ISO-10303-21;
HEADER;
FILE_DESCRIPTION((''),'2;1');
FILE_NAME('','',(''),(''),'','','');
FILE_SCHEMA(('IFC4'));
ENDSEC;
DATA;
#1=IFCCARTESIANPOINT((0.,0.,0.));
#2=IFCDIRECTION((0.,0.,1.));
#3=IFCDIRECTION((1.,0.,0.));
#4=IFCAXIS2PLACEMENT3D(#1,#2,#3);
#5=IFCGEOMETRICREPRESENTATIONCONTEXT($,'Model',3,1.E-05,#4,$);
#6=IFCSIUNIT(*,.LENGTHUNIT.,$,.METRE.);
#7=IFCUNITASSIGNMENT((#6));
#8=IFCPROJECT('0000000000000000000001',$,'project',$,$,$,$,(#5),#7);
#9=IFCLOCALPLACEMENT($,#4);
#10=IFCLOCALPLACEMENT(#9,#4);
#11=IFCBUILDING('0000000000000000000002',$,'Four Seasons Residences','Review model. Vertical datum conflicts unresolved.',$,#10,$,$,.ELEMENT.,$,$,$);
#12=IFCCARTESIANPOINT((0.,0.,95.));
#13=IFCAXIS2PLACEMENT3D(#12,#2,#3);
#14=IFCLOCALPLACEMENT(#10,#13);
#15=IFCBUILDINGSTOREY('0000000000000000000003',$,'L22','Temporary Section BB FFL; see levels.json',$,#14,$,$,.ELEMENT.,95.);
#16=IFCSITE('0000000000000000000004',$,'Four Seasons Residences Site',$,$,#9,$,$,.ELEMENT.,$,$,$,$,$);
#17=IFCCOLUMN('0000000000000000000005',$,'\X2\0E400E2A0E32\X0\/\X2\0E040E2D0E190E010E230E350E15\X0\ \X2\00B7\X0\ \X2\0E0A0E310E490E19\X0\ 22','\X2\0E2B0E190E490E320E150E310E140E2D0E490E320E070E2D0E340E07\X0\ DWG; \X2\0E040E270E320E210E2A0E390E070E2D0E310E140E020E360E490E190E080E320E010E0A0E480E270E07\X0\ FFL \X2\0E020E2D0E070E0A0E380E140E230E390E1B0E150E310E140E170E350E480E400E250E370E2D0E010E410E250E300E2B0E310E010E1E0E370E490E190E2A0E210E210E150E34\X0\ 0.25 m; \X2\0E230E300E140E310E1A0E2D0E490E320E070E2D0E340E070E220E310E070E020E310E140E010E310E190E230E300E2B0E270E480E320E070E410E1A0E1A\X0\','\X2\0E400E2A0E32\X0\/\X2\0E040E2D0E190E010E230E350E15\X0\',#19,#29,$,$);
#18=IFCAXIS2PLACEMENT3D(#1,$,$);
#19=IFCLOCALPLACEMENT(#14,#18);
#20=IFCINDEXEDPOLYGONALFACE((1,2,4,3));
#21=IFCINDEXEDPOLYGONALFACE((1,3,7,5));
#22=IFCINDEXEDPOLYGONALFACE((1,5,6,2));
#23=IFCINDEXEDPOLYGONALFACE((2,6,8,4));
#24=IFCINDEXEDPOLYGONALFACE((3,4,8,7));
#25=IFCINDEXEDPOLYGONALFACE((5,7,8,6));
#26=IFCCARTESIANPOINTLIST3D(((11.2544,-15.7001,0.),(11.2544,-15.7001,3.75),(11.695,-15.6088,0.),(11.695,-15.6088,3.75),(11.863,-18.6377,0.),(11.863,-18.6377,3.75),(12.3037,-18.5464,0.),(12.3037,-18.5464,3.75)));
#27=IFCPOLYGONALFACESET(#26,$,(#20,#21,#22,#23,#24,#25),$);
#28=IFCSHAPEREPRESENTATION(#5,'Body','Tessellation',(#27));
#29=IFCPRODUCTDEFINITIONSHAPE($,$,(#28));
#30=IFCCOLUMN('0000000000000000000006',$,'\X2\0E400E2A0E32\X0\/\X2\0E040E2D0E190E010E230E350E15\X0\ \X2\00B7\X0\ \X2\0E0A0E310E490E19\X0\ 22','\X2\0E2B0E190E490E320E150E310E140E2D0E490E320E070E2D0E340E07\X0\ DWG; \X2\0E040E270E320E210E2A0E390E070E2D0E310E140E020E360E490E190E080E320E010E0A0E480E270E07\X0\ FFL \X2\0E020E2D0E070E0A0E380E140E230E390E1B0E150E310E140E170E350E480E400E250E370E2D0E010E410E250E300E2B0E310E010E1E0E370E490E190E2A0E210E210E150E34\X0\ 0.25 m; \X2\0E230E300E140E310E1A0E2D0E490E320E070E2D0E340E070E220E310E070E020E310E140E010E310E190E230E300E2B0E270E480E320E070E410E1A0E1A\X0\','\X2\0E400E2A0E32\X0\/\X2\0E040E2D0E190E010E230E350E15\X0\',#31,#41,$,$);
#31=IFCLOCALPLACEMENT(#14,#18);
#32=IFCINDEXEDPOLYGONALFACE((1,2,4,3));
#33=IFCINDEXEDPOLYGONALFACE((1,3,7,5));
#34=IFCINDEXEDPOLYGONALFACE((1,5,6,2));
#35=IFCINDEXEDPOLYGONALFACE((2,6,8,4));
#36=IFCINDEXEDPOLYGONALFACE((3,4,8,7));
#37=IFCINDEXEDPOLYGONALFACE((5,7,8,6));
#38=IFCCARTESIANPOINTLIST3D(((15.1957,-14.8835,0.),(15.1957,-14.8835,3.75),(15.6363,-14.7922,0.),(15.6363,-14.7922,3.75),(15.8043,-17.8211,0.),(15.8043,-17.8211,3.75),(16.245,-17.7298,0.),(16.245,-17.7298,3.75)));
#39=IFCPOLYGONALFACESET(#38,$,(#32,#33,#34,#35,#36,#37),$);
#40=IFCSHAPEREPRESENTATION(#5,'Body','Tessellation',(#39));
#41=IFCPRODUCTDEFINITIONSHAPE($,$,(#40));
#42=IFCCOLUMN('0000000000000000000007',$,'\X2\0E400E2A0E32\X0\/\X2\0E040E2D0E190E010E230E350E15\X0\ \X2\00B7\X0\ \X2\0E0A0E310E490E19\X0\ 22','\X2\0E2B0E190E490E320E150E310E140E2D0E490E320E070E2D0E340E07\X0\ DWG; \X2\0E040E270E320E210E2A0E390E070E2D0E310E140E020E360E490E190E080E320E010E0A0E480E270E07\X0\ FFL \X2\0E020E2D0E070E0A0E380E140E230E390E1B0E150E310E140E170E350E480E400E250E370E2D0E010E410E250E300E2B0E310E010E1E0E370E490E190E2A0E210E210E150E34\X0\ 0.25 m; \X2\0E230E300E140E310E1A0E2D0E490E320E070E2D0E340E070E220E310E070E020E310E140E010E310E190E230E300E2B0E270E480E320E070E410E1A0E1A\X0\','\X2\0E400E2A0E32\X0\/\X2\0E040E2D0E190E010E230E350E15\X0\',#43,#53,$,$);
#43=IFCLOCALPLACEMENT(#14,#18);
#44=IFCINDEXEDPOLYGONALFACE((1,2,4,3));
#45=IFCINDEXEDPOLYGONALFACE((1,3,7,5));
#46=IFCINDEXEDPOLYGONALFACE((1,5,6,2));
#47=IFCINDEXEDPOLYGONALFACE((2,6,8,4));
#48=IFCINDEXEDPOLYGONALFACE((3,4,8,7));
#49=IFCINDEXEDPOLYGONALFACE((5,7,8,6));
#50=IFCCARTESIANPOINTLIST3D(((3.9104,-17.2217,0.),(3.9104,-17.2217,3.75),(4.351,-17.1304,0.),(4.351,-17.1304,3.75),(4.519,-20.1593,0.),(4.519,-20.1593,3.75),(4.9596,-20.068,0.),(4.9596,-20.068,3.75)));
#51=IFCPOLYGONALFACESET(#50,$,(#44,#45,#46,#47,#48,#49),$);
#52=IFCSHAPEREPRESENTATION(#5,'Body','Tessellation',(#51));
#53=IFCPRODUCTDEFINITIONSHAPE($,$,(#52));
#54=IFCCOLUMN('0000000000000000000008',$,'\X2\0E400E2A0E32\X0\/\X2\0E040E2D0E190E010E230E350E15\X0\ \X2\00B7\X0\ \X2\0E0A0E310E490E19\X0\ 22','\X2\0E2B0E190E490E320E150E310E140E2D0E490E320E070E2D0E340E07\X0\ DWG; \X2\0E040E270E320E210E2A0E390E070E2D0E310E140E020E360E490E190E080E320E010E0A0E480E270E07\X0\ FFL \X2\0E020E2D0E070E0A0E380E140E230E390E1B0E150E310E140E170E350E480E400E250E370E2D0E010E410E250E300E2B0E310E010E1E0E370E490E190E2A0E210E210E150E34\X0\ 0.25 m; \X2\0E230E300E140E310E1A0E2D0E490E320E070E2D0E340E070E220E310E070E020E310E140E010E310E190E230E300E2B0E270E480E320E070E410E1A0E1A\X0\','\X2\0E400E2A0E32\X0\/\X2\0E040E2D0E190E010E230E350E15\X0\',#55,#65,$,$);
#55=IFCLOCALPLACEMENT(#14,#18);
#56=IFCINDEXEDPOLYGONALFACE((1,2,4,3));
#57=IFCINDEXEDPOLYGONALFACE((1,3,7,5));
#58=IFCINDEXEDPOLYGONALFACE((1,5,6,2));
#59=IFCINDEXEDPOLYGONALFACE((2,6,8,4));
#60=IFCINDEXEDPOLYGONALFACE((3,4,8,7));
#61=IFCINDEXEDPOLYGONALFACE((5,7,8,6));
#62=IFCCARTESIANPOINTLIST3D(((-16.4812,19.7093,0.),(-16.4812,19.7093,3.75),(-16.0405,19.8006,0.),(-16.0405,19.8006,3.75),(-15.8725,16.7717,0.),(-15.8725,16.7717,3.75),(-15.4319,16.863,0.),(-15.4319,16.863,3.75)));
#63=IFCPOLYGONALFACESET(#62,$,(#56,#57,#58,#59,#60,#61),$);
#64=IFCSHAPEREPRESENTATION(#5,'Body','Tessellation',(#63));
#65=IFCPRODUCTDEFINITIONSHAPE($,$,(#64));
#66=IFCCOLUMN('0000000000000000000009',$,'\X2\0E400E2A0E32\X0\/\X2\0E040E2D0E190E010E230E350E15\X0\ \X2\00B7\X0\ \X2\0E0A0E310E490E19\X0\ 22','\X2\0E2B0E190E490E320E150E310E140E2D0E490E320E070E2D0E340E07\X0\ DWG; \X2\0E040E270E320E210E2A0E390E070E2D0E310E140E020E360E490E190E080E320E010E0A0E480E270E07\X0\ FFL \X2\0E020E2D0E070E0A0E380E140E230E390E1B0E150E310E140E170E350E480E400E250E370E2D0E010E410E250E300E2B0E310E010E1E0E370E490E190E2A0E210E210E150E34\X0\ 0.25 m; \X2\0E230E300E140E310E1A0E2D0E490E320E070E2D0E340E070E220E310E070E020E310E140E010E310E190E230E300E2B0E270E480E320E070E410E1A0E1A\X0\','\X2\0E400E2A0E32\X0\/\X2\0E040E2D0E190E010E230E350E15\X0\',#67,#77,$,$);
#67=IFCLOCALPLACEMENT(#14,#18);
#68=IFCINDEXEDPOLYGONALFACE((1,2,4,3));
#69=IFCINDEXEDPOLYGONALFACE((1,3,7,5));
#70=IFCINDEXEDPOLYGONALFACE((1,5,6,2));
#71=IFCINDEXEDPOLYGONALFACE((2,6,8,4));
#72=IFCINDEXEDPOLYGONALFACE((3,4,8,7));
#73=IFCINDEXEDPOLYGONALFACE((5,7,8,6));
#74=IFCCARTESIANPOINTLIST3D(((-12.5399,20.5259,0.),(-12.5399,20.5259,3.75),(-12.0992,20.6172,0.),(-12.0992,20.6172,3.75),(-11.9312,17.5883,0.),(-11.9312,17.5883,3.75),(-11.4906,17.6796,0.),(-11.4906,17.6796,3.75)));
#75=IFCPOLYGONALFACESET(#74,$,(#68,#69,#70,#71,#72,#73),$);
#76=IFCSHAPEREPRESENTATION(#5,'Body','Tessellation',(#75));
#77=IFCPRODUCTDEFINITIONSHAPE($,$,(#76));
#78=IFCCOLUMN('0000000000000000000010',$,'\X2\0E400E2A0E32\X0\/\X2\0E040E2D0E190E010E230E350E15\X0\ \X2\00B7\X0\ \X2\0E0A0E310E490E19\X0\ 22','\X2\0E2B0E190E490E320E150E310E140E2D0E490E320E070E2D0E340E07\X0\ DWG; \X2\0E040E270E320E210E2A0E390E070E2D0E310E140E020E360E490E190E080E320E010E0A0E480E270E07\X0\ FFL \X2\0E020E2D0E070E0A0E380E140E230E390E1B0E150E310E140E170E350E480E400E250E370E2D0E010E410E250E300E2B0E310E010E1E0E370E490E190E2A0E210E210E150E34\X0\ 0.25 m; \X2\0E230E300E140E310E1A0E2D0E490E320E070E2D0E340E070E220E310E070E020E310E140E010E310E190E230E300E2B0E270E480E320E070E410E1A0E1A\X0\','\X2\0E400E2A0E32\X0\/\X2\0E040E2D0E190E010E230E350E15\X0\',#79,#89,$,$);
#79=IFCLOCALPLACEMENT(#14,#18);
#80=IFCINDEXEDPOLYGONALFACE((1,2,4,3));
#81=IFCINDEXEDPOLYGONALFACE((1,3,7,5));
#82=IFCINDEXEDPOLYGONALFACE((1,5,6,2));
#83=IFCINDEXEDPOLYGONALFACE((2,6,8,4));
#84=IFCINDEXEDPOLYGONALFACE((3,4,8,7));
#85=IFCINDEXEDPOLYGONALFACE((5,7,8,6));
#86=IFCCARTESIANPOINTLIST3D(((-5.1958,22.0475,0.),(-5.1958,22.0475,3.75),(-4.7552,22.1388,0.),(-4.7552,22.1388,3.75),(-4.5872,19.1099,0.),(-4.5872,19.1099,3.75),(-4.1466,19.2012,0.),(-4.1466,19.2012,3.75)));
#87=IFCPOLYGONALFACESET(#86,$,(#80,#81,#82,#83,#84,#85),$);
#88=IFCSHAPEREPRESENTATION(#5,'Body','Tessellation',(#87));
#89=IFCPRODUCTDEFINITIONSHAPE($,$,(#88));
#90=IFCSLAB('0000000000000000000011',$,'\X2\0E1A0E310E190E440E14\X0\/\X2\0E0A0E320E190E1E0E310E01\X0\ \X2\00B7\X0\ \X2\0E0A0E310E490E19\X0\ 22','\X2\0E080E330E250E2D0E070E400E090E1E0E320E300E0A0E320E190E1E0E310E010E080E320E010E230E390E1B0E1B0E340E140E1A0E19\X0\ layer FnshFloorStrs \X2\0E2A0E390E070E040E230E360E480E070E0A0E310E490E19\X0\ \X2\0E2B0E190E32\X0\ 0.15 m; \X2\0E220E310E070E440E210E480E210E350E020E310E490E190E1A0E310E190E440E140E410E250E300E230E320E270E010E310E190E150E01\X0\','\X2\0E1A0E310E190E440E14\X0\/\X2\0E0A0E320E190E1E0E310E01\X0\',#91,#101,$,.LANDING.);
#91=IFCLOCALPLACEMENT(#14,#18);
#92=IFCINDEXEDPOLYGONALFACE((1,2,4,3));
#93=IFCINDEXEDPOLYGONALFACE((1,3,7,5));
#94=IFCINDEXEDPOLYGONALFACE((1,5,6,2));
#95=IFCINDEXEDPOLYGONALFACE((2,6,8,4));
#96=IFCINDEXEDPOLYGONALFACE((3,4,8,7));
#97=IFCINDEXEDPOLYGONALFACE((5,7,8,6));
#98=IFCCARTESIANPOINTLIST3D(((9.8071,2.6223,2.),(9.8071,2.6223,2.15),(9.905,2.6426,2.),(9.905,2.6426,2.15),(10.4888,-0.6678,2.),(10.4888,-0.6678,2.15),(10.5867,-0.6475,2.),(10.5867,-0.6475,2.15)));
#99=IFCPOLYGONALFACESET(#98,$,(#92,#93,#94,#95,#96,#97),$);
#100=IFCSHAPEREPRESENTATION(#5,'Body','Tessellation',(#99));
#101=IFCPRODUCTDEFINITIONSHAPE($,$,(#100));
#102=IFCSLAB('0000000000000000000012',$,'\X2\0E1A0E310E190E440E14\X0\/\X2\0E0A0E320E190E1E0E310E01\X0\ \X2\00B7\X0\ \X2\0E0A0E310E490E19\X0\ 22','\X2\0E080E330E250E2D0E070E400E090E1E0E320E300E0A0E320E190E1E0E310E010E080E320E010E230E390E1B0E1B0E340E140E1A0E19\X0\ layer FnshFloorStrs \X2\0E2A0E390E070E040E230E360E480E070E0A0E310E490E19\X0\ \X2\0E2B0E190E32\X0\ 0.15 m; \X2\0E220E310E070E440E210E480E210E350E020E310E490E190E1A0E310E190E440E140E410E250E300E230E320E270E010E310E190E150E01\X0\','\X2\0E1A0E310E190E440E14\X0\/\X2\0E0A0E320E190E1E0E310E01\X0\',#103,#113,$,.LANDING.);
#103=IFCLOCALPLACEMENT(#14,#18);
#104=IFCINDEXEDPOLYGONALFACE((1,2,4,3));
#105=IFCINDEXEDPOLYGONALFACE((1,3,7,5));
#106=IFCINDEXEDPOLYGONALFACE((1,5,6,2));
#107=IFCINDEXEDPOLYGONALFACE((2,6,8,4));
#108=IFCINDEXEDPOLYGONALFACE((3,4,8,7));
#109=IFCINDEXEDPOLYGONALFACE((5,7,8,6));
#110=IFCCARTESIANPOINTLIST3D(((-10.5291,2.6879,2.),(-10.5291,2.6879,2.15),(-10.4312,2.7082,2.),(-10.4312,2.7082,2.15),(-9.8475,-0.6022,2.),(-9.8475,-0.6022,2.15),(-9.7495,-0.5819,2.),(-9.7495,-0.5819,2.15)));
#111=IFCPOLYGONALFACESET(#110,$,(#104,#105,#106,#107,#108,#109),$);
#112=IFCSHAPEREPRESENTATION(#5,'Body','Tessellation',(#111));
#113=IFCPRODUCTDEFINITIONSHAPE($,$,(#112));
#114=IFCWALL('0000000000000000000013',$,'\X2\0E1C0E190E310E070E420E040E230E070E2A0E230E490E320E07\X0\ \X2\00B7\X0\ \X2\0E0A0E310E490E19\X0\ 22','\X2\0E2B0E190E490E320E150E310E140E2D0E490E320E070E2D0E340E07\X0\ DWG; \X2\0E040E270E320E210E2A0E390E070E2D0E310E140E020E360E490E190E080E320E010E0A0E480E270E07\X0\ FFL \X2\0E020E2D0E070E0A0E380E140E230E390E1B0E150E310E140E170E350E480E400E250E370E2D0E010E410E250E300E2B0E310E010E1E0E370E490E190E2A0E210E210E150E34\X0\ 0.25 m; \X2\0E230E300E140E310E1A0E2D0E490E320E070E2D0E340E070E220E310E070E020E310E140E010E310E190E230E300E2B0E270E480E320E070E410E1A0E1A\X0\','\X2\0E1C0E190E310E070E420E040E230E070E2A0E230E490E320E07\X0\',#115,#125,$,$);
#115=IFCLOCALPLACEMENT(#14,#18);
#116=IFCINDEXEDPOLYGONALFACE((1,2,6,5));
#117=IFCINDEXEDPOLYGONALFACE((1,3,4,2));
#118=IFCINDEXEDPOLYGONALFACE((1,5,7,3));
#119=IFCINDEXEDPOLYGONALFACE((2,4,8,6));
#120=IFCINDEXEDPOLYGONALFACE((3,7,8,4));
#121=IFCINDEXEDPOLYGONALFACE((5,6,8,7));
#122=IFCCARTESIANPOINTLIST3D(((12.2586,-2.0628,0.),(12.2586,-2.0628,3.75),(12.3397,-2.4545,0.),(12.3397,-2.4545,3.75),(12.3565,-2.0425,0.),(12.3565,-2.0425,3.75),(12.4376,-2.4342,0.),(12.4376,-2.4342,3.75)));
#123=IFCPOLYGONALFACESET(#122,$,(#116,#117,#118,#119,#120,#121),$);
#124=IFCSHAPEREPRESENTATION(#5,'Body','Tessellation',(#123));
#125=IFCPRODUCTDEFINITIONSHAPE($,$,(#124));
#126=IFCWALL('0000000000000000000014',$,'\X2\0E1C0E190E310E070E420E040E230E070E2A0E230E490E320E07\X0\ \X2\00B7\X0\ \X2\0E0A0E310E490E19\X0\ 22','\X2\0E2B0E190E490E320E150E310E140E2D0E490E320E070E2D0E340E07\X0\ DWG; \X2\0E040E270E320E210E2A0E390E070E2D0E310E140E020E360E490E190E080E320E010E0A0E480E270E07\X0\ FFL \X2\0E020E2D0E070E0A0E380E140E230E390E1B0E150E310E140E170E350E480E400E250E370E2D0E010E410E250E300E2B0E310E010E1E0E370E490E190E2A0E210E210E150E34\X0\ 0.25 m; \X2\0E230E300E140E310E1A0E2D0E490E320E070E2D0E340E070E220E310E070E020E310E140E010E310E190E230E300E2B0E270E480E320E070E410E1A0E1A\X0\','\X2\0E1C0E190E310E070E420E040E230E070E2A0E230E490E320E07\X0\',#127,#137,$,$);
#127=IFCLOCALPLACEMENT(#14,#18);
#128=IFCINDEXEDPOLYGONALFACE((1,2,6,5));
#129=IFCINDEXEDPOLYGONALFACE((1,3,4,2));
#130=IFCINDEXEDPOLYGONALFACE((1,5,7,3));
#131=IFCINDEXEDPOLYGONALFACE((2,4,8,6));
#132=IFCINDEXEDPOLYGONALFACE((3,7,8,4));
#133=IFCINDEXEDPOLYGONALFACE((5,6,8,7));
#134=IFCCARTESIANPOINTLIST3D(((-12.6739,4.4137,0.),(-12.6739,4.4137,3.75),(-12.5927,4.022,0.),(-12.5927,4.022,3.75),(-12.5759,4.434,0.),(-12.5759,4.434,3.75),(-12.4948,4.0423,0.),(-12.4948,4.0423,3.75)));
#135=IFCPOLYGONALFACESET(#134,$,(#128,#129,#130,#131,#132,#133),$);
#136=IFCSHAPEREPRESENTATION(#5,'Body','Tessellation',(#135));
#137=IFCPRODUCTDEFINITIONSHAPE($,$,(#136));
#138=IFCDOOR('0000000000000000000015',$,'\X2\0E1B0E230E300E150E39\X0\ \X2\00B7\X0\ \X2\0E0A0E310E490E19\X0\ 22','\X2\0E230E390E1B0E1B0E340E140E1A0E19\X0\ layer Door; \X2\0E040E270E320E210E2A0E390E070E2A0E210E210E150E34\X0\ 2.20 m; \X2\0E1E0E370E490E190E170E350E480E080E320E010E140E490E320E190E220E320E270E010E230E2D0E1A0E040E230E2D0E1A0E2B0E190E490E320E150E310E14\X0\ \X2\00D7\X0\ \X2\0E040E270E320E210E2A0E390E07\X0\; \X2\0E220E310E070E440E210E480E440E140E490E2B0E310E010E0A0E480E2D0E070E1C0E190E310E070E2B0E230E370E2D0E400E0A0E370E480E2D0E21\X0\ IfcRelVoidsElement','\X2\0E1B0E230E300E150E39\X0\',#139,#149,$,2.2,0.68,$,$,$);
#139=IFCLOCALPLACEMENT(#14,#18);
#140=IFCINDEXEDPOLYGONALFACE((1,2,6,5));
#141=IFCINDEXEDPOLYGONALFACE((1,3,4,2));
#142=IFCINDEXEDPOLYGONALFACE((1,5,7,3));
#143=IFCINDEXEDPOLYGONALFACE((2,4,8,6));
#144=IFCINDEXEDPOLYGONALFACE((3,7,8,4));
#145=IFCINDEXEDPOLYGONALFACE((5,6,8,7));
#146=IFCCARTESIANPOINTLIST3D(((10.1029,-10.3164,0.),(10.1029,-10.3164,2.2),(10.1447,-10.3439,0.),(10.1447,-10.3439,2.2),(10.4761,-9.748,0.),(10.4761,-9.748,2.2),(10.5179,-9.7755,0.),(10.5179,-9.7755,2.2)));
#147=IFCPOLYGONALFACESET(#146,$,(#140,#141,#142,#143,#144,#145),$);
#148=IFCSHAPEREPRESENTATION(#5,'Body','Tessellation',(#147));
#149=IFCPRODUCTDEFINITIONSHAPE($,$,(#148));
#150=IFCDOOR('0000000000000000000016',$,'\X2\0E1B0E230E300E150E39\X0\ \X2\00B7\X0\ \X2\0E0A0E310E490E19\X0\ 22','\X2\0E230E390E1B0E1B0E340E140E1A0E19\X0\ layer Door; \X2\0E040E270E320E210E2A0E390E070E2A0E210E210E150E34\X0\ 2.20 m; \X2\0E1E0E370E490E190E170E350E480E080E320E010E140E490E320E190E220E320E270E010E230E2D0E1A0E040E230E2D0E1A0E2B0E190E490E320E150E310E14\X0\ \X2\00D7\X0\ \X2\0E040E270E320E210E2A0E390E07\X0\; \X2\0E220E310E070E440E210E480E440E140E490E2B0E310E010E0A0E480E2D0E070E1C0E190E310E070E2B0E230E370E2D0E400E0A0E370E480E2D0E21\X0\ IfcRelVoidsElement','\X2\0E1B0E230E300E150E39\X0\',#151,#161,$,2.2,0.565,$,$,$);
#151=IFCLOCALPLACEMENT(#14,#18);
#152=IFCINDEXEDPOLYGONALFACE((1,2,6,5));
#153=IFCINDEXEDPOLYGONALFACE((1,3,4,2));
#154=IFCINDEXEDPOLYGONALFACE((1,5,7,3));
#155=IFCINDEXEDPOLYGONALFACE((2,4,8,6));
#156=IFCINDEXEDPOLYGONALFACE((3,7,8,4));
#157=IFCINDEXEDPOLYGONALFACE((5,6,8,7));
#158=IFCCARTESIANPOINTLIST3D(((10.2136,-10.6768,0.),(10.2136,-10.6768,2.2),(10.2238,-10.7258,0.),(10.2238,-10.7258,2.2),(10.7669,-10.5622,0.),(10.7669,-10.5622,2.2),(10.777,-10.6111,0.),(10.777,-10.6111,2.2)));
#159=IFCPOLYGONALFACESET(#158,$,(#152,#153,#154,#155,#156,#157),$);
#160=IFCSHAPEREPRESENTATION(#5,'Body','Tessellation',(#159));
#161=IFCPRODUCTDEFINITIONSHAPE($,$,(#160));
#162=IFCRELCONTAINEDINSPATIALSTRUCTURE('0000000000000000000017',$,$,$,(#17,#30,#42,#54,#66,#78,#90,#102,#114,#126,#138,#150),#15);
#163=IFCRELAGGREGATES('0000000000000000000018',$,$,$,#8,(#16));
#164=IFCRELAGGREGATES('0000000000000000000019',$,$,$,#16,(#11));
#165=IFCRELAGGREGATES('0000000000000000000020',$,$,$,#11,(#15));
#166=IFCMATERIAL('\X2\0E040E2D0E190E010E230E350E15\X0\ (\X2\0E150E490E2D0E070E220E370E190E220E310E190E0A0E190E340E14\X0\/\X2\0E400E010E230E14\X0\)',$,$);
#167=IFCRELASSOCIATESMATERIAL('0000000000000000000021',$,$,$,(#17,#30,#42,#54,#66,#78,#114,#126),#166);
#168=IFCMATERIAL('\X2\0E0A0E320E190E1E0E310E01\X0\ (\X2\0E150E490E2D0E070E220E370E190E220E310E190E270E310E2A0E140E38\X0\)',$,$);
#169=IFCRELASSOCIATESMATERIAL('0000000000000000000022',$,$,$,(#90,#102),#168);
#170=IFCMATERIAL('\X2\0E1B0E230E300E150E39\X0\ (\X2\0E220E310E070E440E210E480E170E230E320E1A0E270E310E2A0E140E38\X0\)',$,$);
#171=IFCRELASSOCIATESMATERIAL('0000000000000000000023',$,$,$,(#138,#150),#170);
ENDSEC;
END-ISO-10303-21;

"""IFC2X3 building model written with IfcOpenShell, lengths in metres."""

from ifc_helpers import new_model, si_unit, frame, origin_with_axes, place, context, project, spatial, polyline, outline, extrude, material, element, save


model = new_model("IFC2X3")

# Units and contexts
model_context = context("Model", 3, precision=1e-05, world=origin_with_axes())
ifc_project = project(units=[si_unit("LENGTHUNIT", "METRE")], contexts=[model_context])

# Site, building, storey
site_placement = place(None, origin_with_axes())
site = spatial("IfcSite", under=ifc_project, at=site_placement, Name="Four Seasons Residences Site", CompositionType="ELEMENT")
building_placement = place(site_placement, origin_with_axes())
building = spatial("IfcBuilding", under=site, at=building_placement, Name="Four Seasons Residences", Description="Review model. Vertical datum conflicts unresolved.", CompositionType="ELEMENT")
storey_placement = place(building_placement, frame((0.0, 0.0, 95.0), z_axis=(0.0, 0.0, 1.0), x_axis=(1.0, 0.0, 0.0)))
storey = spatial("IfcBuildingStorey", under=building, at=storey_placement, Name="L22", Description="Temporary Section BB FFL; see levels.json", CompositionType="ELEMENT", Elevation=95.0)

# Columns
ifc_material_1 = material(Name="คอนกรีต (ต้องยืนยันชนิด/เกรด)")
column_1_placement = place(storey_placement, origin_with_axes())
element("IfcColumn", 1, at=column_1_placement, inside=storey, material=ifc_material_1, Name="เสา/คอนกรีต · ชั้น 22", Description="หน้าตัดอ้างอิง DWG; ความสูงอัดขึ้นจากช่วง FFL ของชุดรูปตัดที่เลือกและหักพื้นสมมติ 0.25 m; ระดับอ้างอิงยังขัดกันระหว่างแบบ", ObjectType="เสา/คอนกรีต", context=model_context, shape_type="SweptSolid", body=[
    extrude(outline(polyline([(12.3037, -18.5464), (11.863, -18.6377), (11.2544, -15.7001), (11.695, -15.6088), (12.3037, -18.5464)])), origin_with_axes(), (0.0, 0.0, 1.0), 3.75),
])
column_2_placement = place(storey_placement, origin_with_axes())
element("IfcColumn", 2, at=column_2_placement, inside=storey, material=ifc_material_1, Name="เสา/คอนกรีต · ชั้น 22", Description="หน้าตัดอ้างอิง DWG; ความสูงอัดขึ้นจากช่วง FFL ของชุดรูปตัดที่เลือกและหักพื้นสมมติ 0.25 m; ระดับอ้างอิงยังขัดกันระหว่างแบบ", ObjectType="เสา/คอนกรีต", context=model_context, shape_type="SweptSolid", body=[
    extrude(outline(polyline([(16.245, -17.7298), (15.8043, -17.8211), (15.1957, -14.8835), (15.6363, -14.7922), (16.245, -17.7298)])), origin_with_axes(), (0.0, 0.0, 1.0), 3.75),
])
column_3_placement = place(storey_placement, origin_with_axes())
element("IfcColumn", 3, at=column_3_placement, inside=storey, material=ifc_material_1, Name="เสา/คอนกรีต · ชั้น 22", Description="หน้าตัดอ้างอิง DWG; ความสูงอัดขึ้นจากช่วง FFL ของชุดรูปตัดที่เลือกและหักพื้นสมมติ 0.25 m; ระดับอ้างอิงยังขัดกันระหว่างแบบ", ObjectType="เสา/คอนกรีต", context=model_context, shape_type="SweptSolid", body=[
    extrude(outline(polyline([(4.9596, -20.068), (4.519, -20.1593), (3.9104, -17.2217), (4.351, -17.1304), (4.9596, -20.068)])), origin_with_axes(), (0.0, 0.0, 1.0), 3.75),
])
column_4_placement = place(storey_placement, origin_with_axes())
element("IfcColumn", 4, at=column_4_placement, inside=storey, material=ifc_material_1, Name="เสา/คอนกรีต · ชั้น 22", Description="หน้าตัดอ้างอิง DWG; ความสูงอัดขึ้นจากช่วง FFL ของชุดรูปตัดที่เลือกและหักพื้นสมมติ 0.25 m; ระดับอ้างอิงยังขัดกันระหว่างแบบ", ObjectType="เสา/คอนกรีต", context=model_context, shape_type="SweptSolid", body=[
    extrude(outline(polyline([(-15.4319, 16.863), (-15.8725, 16.7717), (-16.4812, 19.7093), (-16.0405, 19.8006), (-15.4319, 16.863)])), origin_with_axes(), (0.0, 0.0, 1.0), 3.75),
])
column_5_placement = place(storey_placement, origin_with_axes())
element("IfcColumn", 5, at=column_5_placement, inside=storey, material=ifc_material_1, Name="เสา/คอนกรีต · ชั้น 22", Description="หน้าตัดอ้างอิง DWG; ความสูงอัดขึ้นจากช่วง FFL ของชุดรูปตัดที่เลือกและหักพื้นสมมติ 0.25 m; ระดับอ้างอิงยังขัดกันระหว่างแบบ", ObjectType="เสา/คอนกรีต", context=model_context, shape_type="SweptSolid", body=[
    extrude(outline(polyline([(-11.4906, 17.6796), (-11.9312, 17.5883), (-12.5399, 20.5259), (-12.0992, 20.6172), (-11.4906, 17.6796)])), origin_with_axes(), (0.0, 0.0, 1.0), 3.75),
])
column_6_placement = place(storey_placement, origin_with_axes())
element("IfcColumn", 6, at=column_6_placement, inside=storey, material=ifc_material_1, Name="เสา/คอนกรีต · ชั้น 22", Description="หน้าตัดอ้างอิง DWG; ความสูงอัดขึ้นจากช่วง FFL ของชุดรูปตัดที่เลือกและหักพื้นสมมติ 0.25 m; ระดับอ้างอิงยังขัดกันระหว่างแบบ", ObjectType="เสา/คอนกรีต", context=model_context, shape_type="SweptSolid", body=[
    extrude(outline(polyline([(-4.1466, 19.2012), (-4.5872, 19.1099), (-5.1958, 22.0475), (-4.7552, 22.1388), (-4.1466, 19.2012)])), origin_with_axes(), (0.0, 0.0, 1.0), 3.75),
])

# Slabs
ifc_material_2 = material(Name="ชานพัก (ต้องยืนยันวัสดุ)")
slab_1_placement = place(storey_placement, origin_with_axes())
element("IfcSlab", 7, at=slab_1_placement, inside=storey, material=ifc_material_2, Name="บันได/ชานพัก · ชั้น 22", Description="จำลองเฉพาะชานพักจากรูปปิดบน layer FnshFloorStrs สูงครึ่งชั้น หนา 0.15 m; ยังไม่มีขั้นบันไดและราวกันตก", ObjectType="บันได/ชานพัก", PredefinedType="LANDING", context=model_context, shape_type="SweptSolid", body=[
    extrude(outline(polyline([(10.5867, -0.6475), (10.4888, -0.6678), (9.8071, 2.6223), (9.905, 2.6426), (10.5867, -0.6475)])), frame((0.0, 0.0, 2.0), z_axis=(0.0, 0.0, 1.0), x_axis=(1.0, 0.0, 0.0)), (0.0, 0.0, 1.0), 0.15),
])
slab_2_placement = place(storey_placement, origin_with_axes())
element("IfcSlab", 8, at=slab_2_placement, inside=storey, material=ifc_material_2, Name="บันได/ชานพัก · ชั้น 22", Description="จำลองเฉพาะชานพักจากรูปปิดบน layer FnshFloorStrs สูงครึ่งชั้น หนา 0.15 m; ยังไม่มีขั้นบันไดและราวกันตก", ObjectType="บันได/ชานพัก", PredefinedType="LANDING", context=model_context, shape_type="SweptSolid", body=[
    extrude(outline(polyline([(-10.5291, 2.6879), (-10.4312, 2.7082), (-9.7495, -0.5819), (-9.8475, -0.6022), (-10.5291, 2.6879)])), frame((0.0, 0.0, 2.0), z_axis=(0.0, 0.0, 1.0), x_axis=(1.0, 0.0, 0.0)), (0.0, 0.0, 1.0), 0.15),
])

# Walls
wall_1_placement = place(storey_placement, origin_with_axes())
element("IfcWall", 9, at=wall_1_placement, inside=storey, material=ifc_material_1, Name="ผนังโครงสร้าง · ชั้น 22", Description="หน้าตัดอ้างอิง DWG; ความสูงอัดขึ้นจากช่วง FFL ของชุดรูปตัดที่เลือกและหักพื้นสมมติ 0.25 m; ระดับอ้างอิงยังขัดกันระหว่างแบบ", ObjectType="ผนังโครงสร้าง", context=model_context, shape_type="SweptSolid", body=[
    extrude(outline(polyline([(12.2586, -2.0628), (12.3397, -2.4545), (12.4376, -2.4342), (12.3565, -2.0425), (12.2586, -2.0628)])), origin_with_axes(), (0.0, 0.0, 1.0), 3.75),
])
wall_2_placement = place(storey_placement, origin_with_axes())
element("IfcWall", 10, at=wall_2_placement, inside=storey, material=ifc_material_1, Name="ผนังโครงสร้าง · ชั้น 22", Description="หน้าตัดอ้างอิง DWG; ความสูงอัดขึ้นจากช่วง FFL ของชุดรูปตัดที่เลือกและหักพื้นสมมติ 0.25 m; ระดับอ้างอิงยังขัดกันระหว่างแบบ", ObjectType="ผนังโครงสร้าง", context=model_context, shape_type="SweptSolid", body=[
    extrude(outline(polyline([(-12.5927, 4.022), (-12.6739, 4.4137), (-12.5759, 4.434), (-12.4948, 4.0423), (-12.5927, 4.022)])), origin_with_axes(), (0.0, 0.0, 1.0), 3.75),
])

# Doors
ifc_material_3 = material(Name="ประตู (ยังไม่ทราบวัสดุ)")
door_1_placement = place(storey_placement, origin_with_axes())
element("IfcDoor", 11, at=door_1_placement, inside=storey, material=ifc_material_3, Name="ประตู · ชั้น 22", Description="รูปปิดบน layer Door; ความสูงสมมติ 2.20 m; พื้นที่จากด้านยาวกรอบครอบหน้าตัด × ความสูง; ยังไม่ได้หักช่องผนังหรือเชื่อม IfcRelVoidsElement", ObjectType="ประตู", OverallHeight=2.2, OverallWidth=0.68, context=model_context, shape_type="SweptSolid", body=[
    extrude(outline(polyline([(10.5179, -9.7755), (10.1447, -10.3439), (10.1029, -10.3164), (10.4761, -9.748), (10.5179, -9.7755)])), origin_with_axes(), (0.0, 0.0, 1.0), 2.2),
])
door_2_placement = place(storey_placement, origin_with_axes())
element("IfcDoor", 12, at=door_2_placement, inside=storey, material=ifc_material_3, Name="ประตู · ชั้น 22", Description="รูปปิดบน layer Door; ความสูงสมมติ 2.20 m; พื้นที่จากด้านยาวกรอบครอบหน้าตัด × ความสูง; ยังไม่ได้หักช่องผนังหรือเชื่อม IfcRelVoidsElement", ObjectType="ประตู", OverallHeight=2.2, OverallWidth=0.565, context=model_context, shape_type="SweptSolid", body=[
    extrude(outline(polyline([(10.7669, -10.5622), (10.2136, -10.6768), (10.2238, -10.7258), (10.777, -10.6111), (10.7669, -10.5622)])), origin_with_axes(), (0.0, 0.0, 1.0), 2.2),
])

save(model, "model.ifc")
